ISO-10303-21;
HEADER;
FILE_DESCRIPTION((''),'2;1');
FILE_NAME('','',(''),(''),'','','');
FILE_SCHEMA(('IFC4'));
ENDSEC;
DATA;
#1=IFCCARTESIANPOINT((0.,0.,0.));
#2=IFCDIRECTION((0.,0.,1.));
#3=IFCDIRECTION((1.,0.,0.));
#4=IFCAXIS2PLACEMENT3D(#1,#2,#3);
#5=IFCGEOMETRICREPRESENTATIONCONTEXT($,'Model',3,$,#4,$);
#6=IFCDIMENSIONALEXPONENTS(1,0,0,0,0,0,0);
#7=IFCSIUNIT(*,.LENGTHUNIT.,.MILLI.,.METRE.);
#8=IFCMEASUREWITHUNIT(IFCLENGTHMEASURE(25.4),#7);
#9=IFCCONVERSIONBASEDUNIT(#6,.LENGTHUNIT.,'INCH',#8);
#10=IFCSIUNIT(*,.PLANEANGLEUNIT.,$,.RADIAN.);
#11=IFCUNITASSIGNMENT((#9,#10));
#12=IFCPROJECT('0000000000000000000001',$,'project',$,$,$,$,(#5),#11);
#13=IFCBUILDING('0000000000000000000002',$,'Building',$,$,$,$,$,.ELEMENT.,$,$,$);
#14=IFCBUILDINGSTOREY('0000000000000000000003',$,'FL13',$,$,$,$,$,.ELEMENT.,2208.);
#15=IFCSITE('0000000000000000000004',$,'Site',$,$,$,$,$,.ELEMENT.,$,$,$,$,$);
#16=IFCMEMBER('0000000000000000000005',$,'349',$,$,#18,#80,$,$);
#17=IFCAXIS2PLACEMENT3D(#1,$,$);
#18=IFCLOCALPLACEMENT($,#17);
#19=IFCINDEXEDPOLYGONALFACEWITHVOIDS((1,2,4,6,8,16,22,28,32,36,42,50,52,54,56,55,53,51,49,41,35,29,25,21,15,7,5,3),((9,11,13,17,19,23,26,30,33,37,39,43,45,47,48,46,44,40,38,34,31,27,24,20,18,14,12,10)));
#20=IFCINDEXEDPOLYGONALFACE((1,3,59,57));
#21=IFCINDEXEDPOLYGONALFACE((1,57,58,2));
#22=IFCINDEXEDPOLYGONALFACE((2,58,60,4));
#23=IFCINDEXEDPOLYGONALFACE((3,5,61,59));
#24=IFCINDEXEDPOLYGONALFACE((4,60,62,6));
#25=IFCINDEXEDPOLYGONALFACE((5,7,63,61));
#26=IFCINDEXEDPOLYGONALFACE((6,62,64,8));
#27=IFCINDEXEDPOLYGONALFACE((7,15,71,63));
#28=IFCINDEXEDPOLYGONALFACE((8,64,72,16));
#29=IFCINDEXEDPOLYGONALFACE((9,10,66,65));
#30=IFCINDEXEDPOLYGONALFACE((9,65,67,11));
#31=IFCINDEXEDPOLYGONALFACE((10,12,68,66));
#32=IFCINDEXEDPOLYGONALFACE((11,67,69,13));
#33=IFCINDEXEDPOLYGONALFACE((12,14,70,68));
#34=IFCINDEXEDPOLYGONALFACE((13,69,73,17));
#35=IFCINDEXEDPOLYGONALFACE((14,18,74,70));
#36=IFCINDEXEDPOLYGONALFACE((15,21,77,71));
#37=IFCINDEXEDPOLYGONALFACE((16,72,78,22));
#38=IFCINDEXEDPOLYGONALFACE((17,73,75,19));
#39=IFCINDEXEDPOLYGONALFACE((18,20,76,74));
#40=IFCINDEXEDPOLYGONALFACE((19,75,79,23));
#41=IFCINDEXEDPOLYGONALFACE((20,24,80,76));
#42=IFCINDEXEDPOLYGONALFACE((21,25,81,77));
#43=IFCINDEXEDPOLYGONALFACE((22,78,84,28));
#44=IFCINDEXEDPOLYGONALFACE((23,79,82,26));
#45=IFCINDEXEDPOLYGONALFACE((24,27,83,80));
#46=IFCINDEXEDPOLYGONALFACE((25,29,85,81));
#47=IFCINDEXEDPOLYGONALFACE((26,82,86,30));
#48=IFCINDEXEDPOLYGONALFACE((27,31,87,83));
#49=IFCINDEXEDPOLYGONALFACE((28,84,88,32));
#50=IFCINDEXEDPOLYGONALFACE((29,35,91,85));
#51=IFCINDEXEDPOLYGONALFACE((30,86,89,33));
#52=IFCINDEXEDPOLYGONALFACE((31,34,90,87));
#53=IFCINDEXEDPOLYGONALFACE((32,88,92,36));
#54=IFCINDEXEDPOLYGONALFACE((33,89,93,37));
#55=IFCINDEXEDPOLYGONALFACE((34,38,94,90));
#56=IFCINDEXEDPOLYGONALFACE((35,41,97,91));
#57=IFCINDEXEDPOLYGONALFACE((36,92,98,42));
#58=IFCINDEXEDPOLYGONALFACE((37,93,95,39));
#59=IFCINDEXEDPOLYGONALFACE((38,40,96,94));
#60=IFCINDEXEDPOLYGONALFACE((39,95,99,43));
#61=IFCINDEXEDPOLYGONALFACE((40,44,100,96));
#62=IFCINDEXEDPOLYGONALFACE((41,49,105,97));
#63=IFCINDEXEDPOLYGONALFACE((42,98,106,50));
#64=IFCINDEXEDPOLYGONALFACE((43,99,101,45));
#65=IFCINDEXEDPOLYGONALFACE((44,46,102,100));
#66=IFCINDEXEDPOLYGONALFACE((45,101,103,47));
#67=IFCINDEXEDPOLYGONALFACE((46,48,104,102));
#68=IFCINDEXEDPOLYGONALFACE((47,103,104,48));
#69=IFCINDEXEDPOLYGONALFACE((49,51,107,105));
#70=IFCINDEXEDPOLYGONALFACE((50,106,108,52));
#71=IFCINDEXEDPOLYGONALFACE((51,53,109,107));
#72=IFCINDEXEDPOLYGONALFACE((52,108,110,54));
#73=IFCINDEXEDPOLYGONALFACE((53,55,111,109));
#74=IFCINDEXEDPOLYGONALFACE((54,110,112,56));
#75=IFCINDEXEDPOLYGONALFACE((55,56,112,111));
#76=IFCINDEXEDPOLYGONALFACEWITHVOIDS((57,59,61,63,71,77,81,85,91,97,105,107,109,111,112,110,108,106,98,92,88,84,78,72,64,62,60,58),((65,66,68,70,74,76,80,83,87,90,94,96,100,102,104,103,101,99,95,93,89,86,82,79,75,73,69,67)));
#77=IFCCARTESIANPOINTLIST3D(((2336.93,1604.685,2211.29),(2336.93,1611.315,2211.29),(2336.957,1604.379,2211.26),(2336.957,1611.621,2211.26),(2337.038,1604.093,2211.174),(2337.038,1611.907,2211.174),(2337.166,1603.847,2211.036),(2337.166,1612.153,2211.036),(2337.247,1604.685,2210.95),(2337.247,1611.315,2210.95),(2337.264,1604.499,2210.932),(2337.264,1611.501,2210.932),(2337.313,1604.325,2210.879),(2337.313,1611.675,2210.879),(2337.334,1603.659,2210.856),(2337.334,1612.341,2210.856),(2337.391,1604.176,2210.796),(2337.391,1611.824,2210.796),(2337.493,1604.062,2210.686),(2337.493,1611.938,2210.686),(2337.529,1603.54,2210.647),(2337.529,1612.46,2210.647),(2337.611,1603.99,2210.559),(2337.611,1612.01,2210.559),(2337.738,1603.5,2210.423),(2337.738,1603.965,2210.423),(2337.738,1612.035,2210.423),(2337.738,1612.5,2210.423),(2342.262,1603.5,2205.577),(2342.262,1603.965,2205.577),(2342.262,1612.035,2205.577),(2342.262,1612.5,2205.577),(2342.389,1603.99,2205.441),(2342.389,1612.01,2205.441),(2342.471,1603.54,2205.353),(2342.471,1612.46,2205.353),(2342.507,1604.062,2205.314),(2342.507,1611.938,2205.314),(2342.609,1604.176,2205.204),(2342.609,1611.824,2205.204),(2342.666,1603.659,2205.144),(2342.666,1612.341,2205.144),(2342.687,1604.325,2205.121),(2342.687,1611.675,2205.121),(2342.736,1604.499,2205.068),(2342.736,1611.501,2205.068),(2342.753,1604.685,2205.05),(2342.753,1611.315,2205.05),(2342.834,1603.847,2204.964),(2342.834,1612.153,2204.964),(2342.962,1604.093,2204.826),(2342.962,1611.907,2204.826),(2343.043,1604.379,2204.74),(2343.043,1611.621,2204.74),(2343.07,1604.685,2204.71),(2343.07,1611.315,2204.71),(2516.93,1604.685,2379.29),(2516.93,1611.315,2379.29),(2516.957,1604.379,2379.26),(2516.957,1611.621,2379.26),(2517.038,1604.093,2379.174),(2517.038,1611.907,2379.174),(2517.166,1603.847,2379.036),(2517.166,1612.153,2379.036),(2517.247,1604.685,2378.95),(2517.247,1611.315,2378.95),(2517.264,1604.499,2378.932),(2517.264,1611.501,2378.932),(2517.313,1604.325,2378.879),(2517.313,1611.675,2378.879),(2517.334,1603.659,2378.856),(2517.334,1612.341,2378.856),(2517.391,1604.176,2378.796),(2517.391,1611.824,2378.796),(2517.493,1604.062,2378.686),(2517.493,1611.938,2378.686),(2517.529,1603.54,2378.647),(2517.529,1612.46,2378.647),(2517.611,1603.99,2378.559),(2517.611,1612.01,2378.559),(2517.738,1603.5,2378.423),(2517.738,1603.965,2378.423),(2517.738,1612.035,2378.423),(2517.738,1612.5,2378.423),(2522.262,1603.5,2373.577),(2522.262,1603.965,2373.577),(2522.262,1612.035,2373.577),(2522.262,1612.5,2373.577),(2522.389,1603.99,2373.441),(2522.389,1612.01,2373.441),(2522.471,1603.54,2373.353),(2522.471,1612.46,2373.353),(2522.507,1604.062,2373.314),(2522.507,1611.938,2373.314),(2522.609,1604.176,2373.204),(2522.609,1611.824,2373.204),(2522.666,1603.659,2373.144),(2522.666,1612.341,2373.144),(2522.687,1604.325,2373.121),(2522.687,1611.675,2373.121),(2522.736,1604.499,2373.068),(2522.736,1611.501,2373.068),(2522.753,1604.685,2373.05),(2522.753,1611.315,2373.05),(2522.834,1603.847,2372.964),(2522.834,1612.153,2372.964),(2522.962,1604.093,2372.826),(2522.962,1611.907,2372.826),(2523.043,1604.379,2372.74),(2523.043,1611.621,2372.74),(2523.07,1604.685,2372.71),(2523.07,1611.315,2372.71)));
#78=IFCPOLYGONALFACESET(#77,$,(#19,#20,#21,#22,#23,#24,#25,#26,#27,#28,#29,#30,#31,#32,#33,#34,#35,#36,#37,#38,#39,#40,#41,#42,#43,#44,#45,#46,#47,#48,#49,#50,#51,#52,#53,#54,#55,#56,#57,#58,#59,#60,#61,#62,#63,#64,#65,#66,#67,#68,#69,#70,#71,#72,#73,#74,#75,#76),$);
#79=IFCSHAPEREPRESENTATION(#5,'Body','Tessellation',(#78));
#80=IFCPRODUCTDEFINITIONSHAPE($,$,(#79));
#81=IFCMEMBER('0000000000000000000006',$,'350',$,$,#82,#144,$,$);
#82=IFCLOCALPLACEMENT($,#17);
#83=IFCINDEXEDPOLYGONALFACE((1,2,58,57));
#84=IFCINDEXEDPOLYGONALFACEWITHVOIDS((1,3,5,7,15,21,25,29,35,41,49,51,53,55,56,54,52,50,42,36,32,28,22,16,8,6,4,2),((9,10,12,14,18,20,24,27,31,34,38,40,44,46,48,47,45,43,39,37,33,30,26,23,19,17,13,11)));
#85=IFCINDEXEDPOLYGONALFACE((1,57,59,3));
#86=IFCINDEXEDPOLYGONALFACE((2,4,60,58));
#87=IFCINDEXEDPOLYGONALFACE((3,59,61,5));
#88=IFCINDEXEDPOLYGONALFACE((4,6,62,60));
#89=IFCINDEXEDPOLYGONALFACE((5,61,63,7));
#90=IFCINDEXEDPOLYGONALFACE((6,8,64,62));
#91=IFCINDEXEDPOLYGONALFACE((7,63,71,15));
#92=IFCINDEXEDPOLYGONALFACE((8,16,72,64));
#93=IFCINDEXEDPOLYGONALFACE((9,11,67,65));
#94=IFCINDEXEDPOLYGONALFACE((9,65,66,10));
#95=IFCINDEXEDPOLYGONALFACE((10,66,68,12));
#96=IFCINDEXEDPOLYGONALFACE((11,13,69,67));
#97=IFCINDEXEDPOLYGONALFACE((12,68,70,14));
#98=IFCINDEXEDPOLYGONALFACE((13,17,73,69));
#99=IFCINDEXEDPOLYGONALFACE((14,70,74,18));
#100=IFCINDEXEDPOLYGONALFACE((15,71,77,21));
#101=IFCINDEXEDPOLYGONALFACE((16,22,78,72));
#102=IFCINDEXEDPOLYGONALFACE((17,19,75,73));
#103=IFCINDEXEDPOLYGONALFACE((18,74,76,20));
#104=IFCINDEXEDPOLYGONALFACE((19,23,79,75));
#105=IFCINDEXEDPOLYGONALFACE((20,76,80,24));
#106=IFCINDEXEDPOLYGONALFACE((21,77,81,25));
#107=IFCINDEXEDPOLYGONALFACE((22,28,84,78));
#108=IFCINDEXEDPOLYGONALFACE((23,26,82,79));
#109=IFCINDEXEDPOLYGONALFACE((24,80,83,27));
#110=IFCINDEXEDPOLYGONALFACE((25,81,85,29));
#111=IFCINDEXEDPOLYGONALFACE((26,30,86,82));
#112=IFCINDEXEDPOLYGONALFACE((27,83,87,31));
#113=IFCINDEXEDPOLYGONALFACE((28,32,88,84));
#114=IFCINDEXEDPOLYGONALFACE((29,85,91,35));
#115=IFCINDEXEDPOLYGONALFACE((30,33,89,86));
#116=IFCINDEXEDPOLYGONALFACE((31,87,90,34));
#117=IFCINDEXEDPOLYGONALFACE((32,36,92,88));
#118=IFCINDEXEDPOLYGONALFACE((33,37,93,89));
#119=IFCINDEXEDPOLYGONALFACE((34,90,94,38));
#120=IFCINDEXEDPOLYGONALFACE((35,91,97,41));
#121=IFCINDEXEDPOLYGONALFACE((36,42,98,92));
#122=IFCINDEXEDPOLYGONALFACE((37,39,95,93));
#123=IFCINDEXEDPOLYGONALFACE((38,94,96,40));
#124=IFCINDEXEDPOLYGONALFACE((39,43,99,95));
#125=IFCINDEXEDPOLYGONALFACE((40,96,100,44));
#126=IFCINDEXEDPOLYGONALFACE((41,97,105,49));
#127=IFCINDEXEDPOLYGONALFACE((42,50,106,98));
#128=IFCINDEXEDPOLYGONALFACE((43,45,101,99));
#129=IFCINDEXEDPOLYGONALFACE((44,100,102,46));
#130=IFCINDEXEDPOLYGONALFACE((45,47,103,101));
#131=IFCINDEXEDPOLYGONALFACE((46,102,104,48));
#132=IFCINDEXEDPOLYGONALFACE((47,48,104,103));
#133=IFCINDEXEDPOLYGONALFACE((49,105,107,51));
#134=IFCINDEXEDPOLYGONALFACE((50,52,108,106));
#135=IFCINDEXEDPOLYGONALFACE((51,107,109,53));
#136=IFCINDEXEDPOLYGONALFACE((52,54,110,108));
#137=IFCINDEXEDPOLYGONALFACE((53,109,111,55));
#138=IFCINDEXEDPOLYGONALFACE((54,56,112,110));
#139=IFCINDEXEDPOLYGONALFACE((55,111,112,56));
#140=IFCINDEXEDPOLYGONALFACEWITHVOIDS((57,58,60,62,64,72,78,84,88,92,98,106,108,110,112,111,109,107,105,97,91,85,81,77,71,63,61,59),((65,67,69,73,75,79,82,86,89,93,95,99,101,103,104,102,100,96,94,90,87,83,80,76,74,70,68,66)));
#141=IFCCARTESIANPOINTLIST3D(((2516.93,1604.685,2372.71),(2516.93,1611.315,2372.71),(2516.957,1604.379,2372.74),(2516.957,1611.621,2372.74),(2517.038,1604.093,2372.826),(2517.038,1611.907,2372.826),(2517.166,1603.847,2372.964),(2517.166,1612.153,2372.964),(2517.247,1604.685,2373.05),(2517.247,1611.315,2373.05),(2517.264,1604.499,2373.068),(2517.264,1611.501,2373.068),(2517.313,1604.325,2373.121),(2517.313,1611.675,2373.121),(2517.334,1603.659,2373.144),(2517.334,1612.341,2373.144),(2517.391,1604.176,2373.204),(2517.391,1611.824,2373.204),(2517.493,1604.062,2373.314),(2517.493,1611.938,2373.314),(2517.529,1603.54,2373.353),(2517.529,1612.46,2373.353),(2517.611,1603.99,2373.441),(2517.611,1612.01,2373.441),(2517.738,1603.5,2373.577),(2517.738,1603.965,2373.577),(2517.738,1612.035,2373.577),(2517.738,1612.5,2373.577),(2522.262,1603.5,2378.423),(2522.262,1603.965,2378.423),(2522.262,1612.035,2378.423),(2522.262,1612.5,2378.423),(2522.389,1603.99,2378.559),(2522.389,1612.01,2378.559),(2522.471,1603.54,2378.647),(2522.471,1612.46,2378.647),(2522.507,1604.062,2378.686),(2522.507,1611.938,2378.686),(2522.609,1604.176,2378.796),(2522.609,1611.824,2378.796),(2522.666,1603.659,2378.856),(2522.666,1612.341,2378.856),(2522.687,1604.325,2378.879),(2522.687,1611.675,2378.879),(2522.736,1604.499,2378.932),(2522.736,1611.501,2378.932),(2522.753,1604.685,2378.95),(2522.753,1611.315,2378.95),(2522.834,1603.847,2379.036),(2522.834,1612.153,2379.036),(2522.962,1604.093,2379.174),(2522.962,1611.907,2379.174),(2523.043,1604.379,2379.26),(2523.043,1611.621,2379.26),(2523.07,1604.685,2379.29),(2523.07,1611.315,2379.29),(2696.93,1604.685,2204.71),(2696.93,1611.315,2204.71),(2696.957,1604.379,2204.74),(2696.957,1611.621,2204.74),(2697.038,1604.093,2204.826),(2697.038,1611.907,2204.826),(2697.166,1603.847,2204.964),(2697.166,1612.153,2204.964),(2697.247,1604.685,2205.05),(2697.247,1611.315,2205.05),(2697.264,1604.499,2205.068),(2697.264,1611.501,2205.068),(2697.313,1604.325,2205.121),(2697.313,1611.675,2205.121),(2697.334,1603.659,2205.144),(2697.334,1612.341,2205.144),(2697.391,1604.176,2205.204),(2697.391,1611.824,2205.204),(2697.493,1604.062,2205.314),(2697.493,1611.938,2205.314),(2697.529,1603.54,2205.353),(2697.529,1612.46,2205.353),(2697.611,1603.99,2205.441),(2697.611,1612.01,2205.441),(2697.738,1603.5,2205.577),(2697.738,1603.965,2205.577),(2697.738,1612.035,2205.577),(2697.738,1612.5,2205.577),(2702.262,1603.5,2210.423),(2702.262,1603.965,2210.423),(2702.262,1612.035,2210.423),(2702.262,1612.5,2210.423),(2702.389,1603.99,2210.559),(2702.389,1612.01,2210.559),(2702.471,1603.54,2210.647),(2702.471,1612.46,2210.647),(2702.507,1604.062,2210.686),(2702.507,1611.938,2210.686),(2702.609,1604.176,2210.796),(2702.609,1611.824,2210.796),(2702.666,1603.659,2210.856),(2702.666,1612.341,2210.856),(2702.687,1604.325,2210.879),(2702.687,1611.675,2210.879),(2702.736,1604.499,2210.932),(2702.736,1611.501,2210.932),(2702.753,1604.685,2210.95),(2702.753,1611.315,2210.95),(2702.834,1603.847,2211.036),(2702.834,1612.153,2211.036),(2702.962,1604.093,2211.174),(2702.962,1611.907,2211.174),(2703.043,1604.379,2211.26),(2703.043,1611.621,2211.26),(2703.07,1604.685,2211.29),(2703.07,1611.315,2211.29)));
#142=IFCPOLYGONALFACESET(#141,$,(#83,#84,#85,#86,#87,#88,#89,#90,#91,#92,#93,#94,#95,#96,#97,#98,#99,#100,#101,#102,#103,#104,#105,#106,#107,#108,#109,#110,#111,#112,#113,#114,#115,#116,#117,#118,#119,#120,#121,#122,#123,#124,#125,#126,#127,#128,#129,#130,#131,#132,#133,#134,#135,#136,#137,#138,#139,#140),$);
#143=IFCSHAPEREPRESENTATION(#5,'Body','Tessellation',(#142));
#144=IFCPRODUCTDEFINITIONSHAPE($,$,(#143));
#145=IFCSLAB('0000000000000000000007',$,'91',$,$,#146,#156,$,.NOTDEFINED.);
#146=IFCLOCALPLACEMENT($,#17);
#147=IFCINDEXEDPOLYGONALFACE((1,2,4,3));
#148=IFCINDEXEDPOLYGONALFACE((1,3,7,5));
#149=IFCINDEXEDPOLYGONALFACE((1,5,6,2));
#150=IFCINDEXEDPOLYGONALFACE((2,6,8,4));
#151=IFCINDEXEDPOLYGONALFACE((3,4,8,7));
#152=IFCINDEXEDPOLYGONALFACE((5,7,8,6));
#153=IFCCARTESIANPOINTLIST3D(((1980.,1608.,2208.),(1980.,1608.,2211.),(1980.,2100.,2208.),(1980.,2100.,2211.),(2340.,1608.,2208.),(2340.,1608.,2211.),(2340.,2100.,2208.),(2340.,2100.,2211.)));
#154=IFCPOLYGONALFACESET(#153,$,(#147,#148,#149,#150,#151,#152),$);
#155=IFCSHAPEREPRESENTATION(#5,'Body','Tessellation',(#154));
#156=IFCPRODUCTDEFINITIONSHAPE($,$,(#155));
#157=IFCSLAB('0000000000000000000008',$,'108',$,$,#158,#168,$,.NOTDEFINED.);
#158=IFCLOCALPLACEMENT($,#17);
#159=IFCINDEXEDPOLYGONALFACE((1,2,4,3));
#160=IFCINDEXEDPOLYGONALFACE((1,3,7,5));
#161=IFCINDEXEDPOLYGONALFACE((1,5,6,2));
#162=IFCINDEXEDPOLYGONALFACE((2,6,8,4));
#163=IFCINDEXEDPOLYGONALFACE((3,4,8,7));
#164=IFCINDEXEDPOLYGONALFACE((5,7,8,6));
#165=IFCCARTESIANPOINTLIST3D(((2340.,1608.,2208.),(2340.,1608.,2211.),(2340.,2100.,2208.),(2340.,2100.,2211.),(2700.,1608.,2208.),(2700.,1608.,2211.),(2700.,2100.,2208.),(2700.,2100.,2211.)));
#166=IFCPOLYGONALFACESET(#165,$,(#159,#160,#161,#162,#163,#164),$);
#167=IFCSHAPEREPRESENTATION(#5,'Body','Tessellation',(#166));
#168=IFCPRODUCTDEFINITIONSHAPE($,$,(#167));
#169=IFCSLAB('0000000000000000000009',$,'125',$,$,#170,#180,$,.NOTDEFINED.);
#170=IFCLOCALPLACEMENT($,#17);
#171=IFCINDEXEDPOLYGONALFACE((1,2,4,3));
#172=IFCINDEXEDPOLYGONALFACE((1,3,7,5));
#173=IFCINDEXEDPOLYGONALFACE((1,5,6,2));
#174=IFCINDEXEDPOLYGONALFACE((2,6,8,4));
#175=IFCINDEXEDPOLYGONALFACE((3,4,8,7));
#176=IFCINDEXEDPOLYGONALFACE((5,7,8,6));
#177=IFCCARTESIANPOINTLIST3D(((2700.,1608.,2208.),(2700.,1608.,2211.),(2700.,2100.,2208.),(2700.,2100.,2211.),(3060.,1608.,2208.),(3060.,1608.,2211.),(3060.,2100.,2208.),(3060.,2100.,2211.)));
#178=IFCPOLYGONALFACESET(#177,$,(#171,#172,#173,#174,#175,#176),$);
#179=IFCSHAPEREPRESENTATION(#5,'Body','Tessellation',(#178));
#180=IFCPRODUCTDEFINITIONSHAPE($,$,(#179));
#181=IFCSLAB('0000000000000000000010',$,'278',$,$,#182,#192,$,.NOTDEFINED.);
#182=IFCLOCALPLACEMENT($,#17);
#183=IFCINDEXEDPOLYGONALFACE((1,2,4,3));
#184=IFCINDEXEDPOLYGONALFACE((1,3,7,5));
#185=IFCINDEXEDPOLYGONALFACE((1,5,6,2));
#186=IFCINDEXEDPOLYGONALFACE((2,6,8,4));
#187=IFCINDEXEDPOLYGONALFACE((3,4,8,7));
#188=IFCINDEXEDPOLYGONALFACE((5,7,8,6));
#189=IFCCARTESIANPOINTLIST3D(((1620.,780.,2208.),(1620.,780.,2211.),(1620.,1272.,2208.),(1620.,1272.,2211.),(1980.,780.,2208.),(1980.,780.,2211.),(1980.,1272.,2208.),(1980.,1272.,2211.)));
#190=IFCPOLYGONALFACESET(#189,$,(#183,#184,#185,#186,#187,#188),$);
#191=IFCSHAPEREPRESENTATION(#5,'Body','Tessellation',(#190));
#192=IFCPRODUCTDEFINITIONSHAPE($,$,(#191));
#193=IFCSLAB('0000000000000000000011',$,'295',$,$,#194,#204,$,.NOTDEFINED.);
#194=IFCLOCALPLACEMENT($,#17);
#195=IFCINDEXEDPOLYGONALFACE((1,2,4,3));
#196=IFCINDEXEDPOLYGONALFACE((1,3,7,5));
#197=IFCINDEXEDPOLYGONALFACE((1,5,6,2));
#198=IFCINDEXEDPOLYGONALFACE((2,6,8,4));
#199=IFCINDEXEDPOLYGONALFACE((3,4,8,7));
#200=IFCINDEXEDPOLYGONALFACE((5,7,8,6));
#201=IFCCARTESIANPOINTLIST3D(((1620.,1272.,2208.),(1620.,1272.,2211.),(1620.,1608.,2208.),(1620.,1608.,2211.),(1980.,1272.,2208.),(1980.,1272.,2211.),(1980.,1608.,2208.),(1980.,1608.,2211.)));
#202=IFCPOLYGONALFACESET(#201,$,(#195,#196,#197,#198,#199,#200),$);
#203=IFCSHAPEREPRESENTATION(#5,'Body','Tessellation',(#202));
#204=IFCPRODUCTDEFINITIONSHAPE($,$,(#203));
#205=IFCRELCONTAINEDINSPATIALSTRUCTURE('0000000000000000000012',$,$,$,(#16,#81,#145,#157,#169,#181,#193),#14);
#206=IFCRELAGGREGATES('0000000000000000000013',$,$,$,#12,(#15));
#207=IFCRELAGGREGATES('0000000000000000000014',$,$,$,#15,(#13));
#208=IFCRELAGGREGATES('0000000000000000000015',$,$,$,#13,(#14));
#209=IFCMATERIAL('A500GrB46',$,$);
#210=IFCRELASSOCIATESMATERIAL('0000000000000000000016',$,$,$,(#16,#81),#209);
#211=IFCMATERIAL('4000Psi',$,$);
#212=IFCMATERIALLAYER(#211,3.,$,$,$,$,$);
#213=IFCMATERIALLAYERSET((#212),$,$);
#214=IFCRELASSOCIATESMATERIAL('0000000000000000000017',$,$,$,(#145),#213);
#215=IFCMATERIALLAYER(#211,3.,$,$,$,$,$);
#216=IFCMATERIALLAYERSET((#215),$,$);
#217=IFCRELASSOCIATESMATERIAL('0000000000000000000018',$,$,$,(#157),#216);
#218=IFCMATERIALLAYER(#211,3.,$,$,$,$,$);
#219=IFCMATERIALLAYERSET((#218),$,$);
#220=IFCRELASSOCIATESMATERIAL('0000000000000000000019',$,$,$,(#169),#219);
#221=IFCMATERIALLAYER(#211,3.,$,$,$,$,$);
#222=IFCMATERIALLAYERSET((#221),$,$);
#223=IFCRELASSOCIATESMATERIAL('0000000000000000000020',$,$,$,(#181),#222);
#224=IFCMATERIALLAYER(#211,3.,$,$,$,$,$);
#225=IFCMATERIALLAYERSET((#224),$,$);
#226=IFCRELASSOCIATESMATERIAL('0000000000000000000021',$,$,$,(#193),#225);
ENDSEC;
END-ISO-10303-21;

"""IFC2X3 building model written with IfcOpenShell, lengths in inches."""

from ifc_helpers import new_model, entity, si_unit, converted_unit, frame, origin_with_axes, origin_2d_with_axis, place, context, project, spatial, polyline, hollow_rectangle, outline, extrude, material, layer, layer_set, layer_usage, element, save


model = new_model("IFC2X3")

# Units and contexts
model_context = context("Model", 3, world=origin_with_axes())
ifc_project = project(units=[converted_unit("LENGTHUNIT", "INCH", entity("IfcLengthMeasure", 25.4), si_unit("LENGTHUNIT", "METRE", prefix="MILLI"), dimensions=[1, 0, 0, 0, 0, 0, 0]), si_unit("PLANEANGLEUNIT", "RADIAN")], contexts=[model_context])

# Site, building, storey
site = spatial("IfcSite", under=ifc_project, Name="Site", CompositionType="ELEMENT")
building = spatial("IfcBuilding", under=site, Name="Building", CompositionType="ELEMENT")
storey = spatial("IfcBuildingStorey", under=building, Name="FL13", CompositionType="ELEMENT", Elevation=2208.0)

# Members
ifc_material_1 = material(Name="A500GrB46")
for number, where, z_axis, x_axis, name in (
    (1, (2340.0, 1608.0, 2208.0), (0.731055, 0.0, 0.682318), (0.0, 1.0, 0.0), "349"),
    (2, (2700.0, 1608.0, 2208.0), (-0.731055, 0.0, 0.682318), (0.0, -1.0, 0.0), "350"),
):
    element("IfcMember", number, at=place(None, frame(where, z_axis=z_axis, x_axis=x_axis)), inside=storey, material=ifc_material_1, Name=name, context=model_context, shape_type="SweptSolid", body=[
        extrude(hollow_rectangle(XDim=9.0, YDim=9.0, WallThickness=0.465, InnerFilletRadius=0.72, OuterFilletRadius=1.185, at=origin_2d_with_axis()), origin_with_axes(), (0.0, 0.0, 1.0), 246.219),
    ])

# Slabs
ifc_material_2 = material(Name="4000Psi")
ifc_layer_1 = layer(ifc_material_2, 3.0)
ifc_layer_set_1 = layer_set([ifc_layer_1])
ifc_layer_usage_1 = layer_usage(ifc_layer_set_1, "AXIS2", "POSITIVE", -3.0)
slab_1_placement = place(None, frame((1980.0, 1608.0, 2208.0), z_axis=(0.0, 0.0, 1.0), x_axis=(1.0, 0.0, 0.0)))
element("IfcSlab", 3, at=slab_1_placement, inside=storey, material=ifc_layer_usage_1, Name="91", PredefinedType="NOTDEFINED", context=model_context, shape_type="SweptSolid", body=[
    extrude(outline(polyline([(0.0, 0.0), (360.0, 0.0), (360.0, 492.0), (0.0, 492.0), (0.0, 0.0)])), origin_with_axes(), (0.0, 0.0, 1.0), 3.0),
])
ifc_layer_2 = layer(ifc_material_2, 3.0)
ifc_layer_set_2 = layer_set([ifc_layer_2])
ifc_layer_usage_2 = layer_usage(ifc_layer_set_2, "AXIS2", "POSITIVE", -3.0)
slab_2_placement = place(None, frame((2340.0, 1608.0, 2208.0), z_axis=(0.0, 0.0, 1.0), x_axis=(1.0, 0.0, 0.0)))
element("IfcSlab", 4, at=slab_2_placement, inside=storey, material=ifc_layer_usage_2, Name="108", PredefinedType="NOTDEFINED", context=model_context, shape_type="SweptSolid", body=[
    extrude(outline(polyline([(0.0, 0.0), (360.0, 0.0), (360.0, 492.0), (0.0, 492.0), (0.0, 0.0)])), origin_with_axes(), (0.0, 0.0, 1.0), 3.0),
])
ifc_layer_3 = layer(ifc_material_2, 3.0)
ifc_layer_set_3 = layer_set([ifc_layer_3])
ifc_layer_usage_3 = layer_usage(ifc_layer_set_3, "AXIS2", "POSITIVE", -3.0)
slab_3_placement = place(None, frame((2700.0, 1608.0, 2208.0), z_axis=(0.0, 0.0, 1.0), x_axis=(1.0, 0.0, 0.0)))
element("IfcSlab", 5, at=slab_3_placement, inside=storey, material=ifc_layer_usage_3, Name="125", PredefinedType="NOTDEFINED", context=model_context, shape_type="SweptSolid", body=[
    extrude(outline(polyline([(0.0, 0.0), (360.0, 0.0), (360.0, 492.0), (0.0, 492.0), (0.0, 0.0)])), origin_with_axes(), (0.0, 0.0, 1.0), 3.0),
])
ifc_layer_4 = layer(ifc_material_2, 3.0)
ifc_layer_set_4 = layer_set([ifc_layer_4])
ifc_layer_usage_4 = layer_usage(ifc_layer_set_4, "AXIS2", "POSITIVE", -3.0)
slab_4_placement = place(None, frame((1620.0, 780.0, 2208.0), z_axis=(0.0, 0.0, 1.0), x_axis=(1.0, 0.0, 0.0)))
element("IfcSlab", 6, at=slab_4_placement, inside=storey, material=ifc_layer_usage_4, Name="278", PredefinedType="NOTDEFINED", context=model_context, shape_type="SweptSolid", body=[
    extrude(outline(polyline([(0.0, 0.0), (360.0, 0.0), (360.0, 492.0), (0.0, 492.0), (0.0, 0.0)])), origin_with_axes(), (0.0, 0.0, 1.0), 3.0),
])
ifc_layer_5 = layer(ifc_material_2, 3.0)
ifc_layer_set_5 = layer_set([ifc_layer_5])
ifc_layer_usage_5 = layer_usage(ifc_layer_set_5, "AXIS2", "POSITIVE", -3.0)
slab_5_placement = place(None, frame((1620.0, 1272.0, 2208.0), z_axis=(0.0, 0.0, 1.0), x_axis=(1.0, 0.0, 0.0)))
element("IfcSlab", 7, at=slab_5_placement, inside=storey, material=ifc_layer_usage_5, Name="295", PredefinedType="NOTDEFINED", context=model_context, shape_type="SweptSolid", body=[
    extrude(outline(polyline([(0.0, 0.0), (360.0, 0.0), (360.0, 336.0), (0.0, 336.0), (0.0, 0.0)])), origin_with_axes(), (0.0, 0.0, 1.0), 3.0),
])

save(model, "model.ifc")
